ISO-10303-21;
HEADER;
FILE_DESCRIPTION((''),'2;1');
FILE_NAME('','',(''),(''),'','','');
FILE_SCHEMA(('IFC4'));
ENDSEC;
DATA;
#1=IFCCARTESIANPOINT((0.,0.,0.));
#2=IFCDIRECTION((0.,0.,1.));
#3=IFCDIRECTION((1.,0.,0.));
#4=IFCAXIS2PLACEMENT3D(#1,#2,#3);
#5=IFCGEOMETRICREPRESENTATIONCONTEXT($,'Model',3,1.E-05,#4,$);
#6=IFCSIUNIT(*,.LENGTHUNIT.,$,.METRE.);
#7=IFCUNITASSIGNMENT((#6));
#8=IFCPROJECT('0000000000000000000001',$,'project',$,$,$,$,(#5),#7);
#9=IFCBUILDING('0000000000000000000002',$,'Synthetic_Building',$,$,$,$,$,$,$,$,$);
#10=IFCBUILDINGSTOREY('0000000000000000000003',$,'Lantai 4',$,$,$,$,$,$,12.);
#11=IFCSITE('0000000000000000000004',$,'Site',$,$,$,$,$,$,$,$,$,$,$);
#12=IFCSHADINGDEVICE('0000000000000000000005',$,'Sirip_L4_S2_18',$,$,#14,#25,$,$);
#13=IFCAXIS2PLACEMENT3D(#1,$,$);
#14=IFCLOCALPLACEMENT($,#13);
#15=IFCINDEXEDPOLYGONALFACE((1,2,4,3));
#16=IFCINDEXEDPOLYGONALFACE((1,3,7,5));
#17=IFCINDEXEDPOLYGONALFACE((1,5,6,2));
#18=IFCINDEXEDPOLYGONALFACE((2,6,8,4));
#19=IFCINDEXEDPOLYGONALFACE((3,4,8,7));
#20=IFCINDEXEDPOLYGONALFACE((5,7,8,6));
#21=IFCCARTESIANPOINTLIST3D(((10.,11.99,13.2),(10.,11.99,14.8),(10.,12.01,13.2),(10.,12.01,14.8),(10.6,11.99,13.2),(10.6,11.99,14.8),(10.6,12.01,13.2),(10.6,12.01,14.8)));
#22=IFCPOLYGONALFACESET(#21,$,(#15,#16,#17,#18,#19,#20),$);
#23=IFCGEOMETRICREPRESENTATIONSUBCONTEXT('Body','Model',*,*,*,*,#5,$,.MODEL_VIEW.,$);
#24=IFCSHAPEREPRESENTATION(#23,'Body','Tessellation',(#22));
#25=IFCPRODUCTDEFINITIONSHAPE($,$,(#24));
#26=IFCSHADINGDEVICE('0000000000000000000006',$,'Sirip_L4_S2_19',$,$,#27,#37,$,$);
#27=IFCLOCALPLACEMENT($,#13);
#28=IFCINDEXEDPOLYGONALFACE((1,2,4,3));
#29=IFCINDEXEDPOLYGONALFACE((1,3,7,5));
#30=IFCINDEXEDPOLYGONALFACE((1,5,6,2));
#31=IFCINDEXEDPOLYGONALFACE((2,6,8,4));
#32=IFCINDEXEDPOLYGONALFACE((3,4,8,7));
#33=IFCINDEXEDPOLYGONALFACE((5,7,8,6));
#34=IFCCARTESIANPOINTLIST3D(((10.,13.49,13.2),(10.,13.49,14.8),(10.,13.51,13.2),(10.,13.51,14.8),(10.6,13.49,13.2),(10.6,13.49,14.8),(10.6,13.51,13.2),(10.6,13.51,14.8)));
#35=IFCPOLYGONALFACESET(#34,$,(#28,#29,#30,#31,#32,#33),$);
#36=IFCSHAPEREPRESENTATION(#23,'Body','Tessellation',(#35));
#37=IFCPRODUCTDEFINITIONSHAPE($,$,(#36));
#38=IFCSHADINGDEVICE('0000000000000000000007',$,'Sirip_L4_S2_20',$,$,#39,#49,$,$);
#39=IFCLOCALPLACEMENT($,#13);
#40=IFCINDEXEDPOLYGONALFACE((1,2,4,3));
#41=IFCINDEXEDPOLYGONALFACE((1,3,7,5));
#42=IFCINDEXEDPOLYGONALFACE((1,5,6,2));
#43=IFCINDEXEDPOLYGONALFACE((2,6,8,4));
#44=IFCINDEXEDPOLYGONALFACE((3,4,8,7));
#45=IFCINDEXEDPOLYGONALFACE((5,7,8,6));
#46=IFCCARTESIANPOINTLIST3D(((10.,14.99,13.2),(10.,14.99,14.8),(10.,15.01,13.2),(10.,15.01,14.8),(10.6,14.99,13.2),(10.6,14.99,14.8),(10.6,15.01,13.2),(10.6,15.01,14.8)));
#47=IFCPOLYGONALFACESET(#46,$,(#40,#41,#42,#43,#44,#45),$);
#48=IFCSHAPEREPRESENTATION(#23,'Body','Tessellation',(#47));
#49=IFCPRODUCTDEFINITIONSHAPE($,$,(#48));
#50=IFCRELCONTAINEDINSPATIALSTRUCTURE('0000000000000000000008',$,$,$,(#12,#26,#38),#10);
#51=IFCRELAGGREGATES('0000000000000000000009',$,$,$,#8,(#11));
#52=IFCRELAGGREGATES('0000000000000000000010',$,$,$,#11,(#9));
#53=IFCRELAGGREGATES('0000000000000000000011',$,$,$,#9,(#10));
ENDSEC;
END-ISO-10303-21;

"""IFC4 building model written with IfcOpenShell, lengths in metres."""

from ifc_helpers import new_model, si_unit, frame, origin_with_axes, place, context, subcontext, project, spatial, polyline, outline, extrude, element, save


model = new_model("IFC4")

# Units and contexts
model_context = context("Model", 3, precision=1e-05, world=origin_with_axes())
body_context = subcontext(model_context, "Body", "Model", "MODEL_VIEW")
ifc_project = project(units=[si_unit("LENGTHUNIT", "METRE")], contexts=[model_context])

# Site, building, storey
site = spatial("IfcSite", under=ifc_project, Name="Site")
building = spatial("IfcBuilding", under=site, Name="Synthetic_Building")
storey = spatial("IfcBuildingStorey", under=building, Name="Lantai 4", Elevation=12.0)

# Shading devices
shading_device_1_placement = place(None, origin_with_axes())
element("IfcShadingDevice", 1, at=shading_device_1_placement, inside=storey, Name="Sirip_L4_S2_18", context=body_context, shape_type="SweptSolid", body=[
    extrude(outline(polyline([(10.0, 11.99), (10.0, 12.01), (10.6, 12.01), (10.6, 11.99), (10.0, 11.99)])), frame((0.0, 0.0, 13.2), z_axis=(0.0, 0.0, 1.0), x_axis=(1.0, 0.0, 0.0)), (0.0, 0.0, 1.0), 1.6),
])
shading_device_2_placement = place(None, origin_with_axes())
element("IfcShadingDevice", 2, at=shading_device_2_placement, inside=storey, Name="Sirip_L4_S2_19", context=body_context, shape_type="SweptSolid", body=[
    extrude(outline(polyline([(10.0, 13.49), (10.0, 13.51), (10.6, 13.51), (10.6, 13.49), (10.0, 13.49)])), frame((0.0, 0.0, 13.2), z_axis=(0.0, 0.0, 1.0), x_axis=(1.0, 0.0, 0.0)), (0.0, 0.0, 1.0), 1.6),
])
shading_device_3_placement = place(None, origin_with_axes())
element("IfcShadingDevice", 3, at=shading_device_3_placement, inside=storey, Name="Sirip_L4_S2_20", context=body_context, shape_type="SweptSolid", body=[
    extrude(outline(polyline([(10.0, 14.99), (10.0, 15.01), (10.6, 15.01), (10.6, 14.99), (10.0, 14.99)])), frame((0.0, 0.0, 13.2), z_axis=(0.0, 0.0, 1.0), x_axis=(1.0, 0.0, 0.0)), (0.0, 0.0, 1.0), 1.6),
])

save(model, "model.ifc")
